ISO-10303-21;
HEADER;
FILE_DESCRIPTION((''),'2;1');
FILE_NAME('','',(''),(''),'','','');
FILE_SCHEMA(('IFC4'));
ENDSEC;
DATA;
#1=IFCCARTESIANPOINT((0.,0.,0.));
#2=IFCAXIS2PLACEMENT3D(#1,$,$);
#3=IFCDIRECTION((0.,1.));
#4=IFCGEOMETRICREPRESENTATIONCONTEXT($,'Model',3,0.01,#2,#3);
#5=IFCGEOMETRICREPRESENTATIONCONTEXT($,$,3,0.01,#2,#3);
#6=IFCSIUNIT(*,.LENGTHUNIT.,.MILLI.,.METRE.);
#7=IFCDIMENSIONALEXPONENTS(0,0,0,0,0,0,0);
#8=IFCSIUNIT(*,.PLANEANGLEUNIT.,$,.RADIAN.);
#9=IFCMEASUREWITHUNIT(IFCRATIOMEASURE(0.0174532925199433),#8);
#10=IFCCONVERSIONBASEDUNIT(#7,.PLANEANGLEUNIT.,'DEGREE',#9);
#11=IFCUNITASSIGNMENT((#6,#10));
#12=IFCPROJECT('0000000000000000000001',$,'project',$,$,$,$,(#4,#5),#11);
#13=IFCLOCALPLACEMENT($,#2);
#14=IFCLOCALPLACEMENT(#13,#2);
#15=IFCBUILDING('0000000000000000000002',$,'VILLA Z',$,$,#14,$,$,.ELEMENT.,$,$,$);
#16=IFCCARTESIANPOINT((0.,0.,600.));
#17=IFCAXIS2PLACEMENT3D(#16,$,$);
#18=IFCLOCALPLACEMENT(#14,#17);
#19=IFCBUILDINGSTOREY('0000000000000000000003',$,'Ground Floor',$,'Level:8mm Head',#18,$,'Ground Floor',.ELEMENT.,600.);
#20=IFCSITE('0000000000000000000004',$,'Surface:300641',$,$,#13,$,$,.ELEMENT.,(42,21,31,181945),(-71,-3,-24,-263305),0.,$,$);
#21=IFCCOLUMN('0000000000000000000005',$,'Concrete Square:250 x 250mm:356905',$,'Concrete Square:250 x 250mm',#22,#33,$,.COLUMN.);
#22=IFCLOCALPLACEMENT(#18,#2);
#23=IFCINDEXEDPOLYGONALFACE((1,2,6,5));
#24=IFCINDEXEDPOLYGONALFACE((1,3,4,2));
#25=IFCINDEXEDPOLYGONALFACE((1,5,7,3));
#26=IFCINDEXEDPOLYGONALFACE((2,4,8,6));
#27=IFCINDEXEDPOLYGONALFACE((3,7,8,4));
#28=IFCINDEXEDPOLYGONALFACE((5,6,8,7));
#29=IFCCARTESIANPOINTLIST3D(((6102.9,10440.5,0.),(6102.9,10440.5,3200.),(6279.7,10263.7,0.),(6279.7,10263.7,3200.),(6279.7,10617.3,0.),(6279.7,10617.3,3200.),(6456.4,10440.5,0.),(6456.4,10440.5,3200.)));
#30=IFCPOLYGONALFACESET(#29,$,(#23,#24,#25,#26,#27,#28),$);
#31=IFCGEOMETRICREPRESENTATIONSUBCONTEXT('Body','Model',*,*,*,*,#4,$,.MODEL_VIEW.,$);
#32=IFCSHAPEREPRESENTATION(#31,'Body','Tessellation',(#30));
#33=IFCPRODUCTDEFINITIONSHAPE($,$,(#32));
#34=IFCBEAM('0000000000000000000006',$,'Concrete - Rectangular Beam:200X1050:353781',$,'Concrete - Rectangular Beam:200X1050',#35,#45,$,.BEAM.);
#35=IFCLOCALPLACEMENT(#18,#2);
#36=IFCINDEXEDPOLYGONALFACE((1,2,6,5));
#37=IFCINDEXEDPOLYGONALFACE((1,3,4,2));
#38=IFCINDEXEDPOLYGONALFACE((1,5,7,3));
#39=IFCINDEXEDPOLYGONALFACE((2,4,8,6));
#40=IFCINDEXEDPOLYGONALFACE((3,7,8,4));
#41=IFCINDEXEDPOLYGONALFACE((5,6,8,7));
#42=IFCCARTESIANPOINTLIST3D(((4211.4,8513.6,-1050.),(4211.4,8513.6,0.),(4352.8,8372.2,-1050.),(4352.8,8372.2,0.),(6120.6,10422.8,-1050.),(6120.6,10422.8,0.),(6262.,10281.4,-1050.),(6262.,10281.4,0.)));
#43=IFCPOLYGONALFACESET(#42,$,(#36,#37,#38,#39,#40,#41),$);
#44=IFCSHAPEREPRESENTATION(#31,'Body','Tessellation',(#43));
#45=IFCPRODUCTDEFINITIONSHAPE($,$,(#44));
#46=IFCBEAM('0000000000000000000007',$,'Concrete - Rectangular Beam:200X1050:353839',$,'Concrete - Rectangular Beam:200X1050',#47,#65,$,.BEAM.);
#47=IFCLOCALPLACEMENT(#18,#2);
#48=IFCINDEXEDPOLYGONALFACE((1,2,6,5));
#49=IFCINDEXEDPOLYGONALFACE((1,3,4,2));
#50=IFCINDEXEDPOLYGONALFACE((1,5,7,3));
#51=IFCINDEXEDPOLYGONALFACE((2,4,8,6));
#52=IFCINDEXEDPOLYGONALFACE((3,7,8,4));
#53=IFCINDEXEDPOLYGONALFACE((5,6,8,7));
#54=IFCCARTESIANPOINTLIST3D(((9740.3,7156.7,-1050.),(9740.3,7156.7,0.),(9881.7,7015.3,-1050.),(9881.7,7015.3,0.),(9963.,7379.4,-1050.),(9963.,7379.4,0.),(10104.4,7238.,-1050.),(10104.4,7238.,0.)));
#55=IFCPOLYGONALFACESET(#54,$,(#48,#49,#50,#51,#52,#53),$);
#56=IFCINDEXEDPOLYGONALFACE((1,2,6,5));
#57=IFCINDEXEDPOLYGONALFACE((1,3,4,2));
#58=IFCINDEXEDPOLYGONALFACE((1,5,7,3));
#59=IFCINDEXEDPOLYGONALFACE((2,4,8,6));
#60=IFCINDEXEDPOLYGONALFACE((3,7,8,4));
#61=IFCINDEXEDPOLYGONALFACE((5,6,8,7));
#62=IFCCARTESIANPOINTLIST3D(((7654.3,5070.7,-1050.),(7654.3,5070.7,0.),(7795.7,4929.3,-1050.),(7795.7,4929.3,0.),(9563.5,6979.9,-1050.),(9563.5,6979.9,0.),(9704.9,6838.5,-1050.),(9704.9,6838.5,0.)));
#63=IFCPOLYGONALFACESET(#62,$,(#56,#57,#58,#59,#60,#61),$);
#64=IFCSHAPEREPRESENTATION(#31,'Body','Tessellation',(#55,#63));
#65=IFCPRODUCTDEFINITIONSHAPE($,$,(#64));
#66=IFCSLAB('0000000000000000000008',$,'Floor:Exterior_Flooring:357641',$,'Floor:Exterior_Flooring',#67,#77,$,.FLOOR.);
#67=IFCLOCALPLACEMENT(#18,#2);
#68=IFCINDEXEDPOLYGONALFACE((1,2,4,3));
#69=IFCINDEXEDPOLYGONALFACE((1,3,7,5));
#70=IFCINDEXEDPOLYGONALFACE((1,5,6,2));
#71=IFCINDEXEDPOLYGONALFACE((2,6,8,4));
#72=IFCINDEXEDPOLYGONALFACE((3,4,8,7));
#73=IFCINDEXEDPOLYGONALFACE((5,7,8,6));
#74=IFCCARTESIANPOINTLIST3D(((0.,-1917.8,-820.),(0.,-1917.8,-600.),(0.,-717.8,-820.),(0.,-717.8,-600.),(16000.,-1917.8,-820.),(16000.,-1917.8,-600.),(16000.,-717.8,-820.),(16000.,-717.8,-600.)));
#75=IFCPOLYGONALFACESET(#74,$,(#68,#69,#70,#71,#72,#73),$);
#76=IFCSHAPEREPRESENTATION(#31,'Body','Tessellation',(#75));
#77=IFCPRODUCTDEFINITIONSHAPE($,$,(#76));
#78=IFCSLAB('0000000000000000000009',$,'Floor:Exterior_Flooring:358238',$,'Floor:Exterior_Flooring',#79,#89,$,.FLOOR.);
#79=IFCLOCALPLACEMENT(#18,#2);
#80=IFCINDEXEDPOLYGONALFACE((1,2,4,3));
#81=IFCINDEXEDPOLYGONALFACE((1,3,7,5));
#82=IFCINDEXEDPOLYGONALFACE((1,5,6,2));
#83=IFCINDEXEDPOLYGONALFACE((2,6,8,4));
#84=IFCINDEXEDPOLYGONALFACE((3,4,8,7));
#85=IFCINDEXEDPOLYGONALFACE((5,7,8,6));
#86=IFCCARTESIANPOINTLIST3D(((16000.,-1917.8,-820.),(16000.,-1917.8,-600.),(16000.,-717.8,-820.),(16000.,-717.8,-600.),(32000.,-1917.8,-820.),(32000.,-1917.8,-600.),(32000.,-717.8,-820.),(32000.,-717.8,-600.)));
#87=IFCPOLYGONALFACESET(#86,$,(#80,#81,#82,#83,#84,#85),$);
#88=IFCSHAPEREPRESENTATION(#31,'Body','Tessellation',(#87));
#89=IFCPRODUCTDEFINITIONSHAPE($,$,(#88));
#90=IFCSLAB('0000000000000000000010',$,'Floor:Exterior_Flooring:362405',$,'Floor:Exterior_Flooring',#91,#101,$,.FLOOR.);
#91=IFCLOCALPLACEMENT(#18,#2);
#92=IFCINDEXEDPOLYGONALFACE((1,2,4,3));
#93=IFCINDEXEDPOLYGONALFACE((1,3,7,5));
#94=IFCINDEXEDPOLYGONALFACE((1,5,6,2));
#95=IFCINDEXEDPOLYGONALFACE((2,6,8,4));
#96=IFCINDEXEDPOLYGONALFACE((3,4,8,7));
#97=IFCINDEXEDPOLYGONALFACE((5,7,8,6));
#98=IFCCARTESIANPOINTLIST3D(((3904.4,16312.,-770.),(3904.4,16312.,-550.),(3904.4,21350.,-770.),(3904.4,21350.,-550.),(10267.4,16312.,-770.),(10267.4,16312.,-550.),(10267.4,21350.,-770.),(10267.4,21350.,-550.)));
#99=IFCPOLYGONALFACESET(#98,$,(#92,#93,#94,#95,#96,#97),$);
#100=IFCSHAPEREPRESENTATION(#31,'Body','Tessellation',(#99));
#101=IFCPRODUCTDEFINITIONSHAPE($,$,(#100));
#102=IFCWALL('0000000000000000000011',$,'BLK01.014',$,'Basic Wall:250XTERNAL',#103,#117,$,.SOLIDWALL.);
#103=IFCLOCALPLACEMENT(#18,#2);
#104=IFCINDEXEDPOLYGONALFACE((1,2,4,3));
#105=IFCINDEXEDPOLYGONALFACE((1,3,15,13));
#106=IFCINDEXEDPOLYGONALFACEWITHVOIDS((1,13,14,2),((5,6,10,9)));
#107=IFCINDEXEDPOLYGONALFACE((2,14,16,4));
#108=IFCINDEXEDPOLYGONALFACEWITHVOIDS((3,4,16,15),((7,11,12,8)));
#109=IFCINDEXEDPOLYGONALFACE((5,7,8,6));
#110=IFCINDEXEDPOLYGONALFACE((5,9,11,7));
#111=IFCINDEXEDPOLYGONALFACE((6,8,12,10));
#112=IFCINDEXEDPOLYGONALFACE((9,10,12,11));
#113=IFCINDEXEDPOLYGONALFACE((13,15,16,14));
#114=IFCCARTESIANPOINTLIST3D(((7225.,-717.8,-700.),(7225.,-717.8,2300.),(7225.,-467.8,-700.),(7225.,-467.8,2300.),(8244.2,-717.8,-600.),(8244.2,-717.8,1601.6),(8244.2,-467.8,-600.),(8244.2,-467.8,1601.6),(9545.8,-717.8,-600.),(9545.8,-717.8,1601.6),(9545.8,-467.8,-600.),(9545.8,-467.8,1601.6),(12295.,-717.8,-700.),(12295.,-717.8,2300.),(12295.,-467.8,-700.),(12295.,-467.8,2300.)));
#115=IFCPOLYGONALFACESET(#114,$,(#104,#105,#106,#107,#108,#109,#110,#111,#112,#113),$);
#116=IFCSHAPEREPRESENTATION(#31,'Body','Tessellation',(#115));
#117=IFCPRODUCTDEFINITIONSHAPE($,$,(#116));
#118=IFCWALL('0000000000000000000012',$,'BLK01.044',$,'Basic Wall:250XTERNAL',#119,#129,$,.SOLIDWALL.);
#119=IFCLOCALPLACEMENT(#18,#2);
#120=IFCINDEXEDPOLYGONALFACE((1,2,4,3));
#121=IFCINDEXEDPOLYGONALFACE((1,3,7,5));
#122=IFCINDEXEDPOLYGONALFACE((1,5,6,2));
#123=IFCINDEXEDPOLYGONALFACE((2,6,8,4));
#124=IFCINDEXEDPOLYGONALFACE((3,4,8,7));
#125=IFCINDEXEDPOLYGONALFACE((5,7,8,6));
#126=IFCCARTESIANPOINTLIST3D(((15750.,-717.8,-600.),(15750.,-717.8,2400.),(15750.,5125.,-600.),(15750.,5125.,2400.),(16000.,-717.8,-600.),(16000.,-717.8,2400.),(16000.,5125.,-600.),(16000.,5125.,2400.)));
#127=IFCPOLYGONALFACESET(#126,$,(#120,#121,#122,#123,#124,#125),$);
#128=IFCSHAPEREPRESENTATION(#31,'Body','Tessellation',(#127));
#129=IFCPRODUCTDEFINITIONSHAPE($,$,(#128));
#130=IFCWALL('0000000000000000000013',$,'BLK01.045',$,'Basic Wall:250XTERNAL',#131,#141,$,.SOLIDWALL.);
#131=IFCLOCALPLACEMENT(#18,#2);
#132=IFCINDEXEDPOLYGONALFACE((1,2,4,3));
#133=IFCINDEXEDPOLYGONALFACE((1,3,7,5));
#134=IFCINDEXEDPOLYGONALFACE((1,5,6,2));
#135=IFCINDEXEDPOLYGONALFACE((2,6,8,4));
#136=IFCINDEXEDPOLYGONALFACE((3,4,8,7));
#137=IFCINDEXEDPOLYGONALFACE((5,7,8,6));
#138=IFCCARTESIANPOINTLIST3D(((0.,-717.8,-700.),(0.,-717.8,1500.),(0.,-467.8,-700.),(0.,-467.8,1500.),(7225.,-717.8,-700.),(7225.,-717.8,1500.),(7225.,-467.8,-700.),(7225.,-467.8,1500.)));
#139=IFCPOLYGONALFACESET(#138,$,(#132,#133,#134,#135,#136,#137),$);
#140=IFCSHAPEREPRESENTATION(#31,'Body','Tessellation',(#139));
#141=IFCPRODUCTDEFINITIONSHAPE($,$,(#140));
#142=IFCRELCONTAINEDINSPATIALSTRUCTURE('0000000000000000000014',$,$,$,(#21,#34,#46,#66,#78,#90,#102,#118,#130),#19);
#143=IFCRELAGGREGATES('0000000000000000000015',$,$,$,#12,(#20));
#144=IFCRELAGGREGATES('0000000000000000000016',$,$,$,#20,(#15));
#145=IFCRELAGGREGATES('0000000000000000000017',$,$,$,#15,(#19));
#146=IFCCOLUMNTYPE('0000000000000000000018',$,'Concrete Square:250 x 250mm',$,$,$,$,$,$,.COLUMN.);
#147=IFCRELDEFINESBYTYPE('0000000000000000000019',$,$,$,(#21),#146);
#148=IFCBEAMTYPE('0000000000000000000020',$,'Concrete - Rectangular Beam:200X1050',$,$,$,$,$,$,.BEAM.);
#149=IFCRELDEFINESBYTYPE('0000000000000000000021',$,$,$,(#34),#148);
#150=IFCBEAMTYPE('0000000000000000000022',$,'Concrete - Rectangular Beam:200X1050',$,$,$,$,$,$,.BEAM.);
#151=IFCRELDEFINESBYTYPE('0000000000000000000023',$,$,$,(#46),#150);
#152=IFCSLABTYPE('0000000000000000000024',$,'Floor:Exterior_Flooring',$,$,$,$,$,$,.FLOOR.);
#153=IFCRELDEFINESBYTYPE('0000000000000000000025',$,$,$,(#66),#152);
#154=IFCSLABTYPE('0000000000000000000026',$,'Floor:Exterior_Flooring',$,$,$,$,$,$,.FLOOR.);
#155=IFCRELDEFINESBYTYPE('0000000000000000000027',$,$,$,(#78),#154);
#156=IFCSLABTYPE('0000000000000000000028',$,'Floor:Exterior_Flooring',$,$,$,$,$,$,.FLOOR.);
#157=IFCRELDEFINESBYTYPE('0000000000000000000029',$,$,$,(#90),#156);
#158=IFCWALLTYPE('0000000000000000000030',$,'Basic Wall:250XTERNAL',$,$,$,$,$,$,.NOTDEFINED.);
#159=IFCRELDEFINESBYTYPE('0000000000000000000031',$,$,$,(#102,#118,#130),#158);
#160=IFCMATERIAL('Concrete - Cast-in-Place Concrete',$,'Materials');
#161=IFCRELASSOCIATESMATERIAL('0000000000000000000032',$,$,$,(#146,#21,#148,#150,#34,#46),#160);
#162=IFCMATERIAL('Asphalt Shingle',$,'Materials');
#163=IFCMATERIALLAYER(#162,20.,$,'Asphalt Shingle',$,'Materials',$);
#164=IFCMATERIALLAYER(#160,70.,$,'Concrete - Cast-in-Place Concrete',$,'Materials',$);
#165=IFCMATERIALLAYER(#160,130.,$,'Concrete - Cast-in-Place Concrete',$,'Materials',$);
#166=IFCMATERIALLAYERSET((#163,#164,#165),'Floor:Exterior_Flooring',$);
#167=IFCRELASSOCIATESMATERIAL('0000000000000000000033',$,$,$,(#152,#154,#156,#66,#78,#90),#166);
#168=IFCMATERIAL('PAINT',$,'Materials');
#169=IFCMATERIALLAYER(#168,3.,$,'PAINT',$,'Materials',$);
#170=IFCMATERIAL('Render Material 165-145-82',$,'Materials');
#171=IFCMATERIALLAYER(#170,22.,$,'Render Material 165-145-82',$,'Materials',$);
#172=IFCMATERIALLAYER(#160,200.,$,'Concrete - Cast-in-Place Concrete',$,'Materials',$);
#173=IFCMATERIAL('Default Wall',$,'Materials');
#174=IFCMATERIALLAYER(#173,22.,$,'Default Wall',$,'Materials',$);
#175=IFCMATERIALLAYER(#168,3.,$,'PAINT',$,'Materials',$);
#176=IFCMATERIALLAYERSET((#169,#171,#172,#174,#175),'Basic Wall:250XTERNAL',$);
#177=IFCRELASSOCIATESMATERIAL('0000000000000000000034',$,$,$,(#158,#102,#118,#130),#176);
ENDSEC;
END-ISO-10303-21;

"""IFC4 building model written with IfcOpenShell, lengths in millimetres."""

from ifc_helpers import new_model, entity, si_unit, converted_unit, direction, frame, frame_2d, origin, origin_2d_with_axis, place, context, subcontext, project, spatial, rectangle, extrude, source, transform, mapped, material, layer, layer_set, layer_usage, material_profile, profile_set, profile_usage, type_object, type_shapes, element, save


model = new_model("IFC4")

# Units and contexts
model_context = context("Model", 3, precision=0.01, world=origin(), true_north=direction((0.0, 1.0)))
context_of_model = context(None, 3, precision=0.01, world=origin(), true_north=direction((0.0, 1.0)))
body_context = subcontext(model_context, "Body", "Model", "MODEL_VIEW")
ifc_project = project(units=[si_unit("LENGTHUNIT", "METRE", prefix="MILLI"), converted_unit("PLANEANGLEUNIT", "DEGREE", entity("IfcRatioMeasure", 0.0174532925199433), si_unit("PLANEANGLEUNIT", "RADIAN"), dimensions=[0, 0, 0, 0, 0, 0, 0])], contexts=[model_context, context_of_model])

# Site, building, storey
site_placement = place(None, origin())
site = spatial("IfcSite", under=ifc_project, at=site_placement, Name="Surface:300641", CompositionType="ELEMENT", RefLatitude=(42, 21, 31, 181945), RefLongitude=(-71, -3, -24, -263305), RefElevation=0.0)
building_placement = place(site_placement, origin())
building = spatial("IfcBuilding", under=site, at=building_placement, Name="VILLA Z", CompositionType="ELEMENT")
storey_placement = place(building_placement, frame((0.0, 0.0, 600.0)))
storey = spatial("IfcBuildingStorey", under=building, at=storey_placement, Name="Ground Floor", ObjectType="Level:8mm Head", LongName="Ground Floor", CompositionType="ELEMENT", Elevation=600.0)

# Column
ifc_material_1 = material(Name="Concrete - Cast-in-Place Concrete", Category="Materials")
ifc_material_profile_1 = material_profile(ifc_material_1, rectangle(XDim=250.0, YDim=250.0, at=frame_2d((0.0, 0.0), x_axis=(1.0, 0.0))), Name="250 x 250mm")
ifc_profile_set_1 = profile_set([ifc_material_profile_1], Name="250 x 250mm")
ifc_profile_usage_1 = profile_usage(ifc_profile_set_1)
column_type = type_object("IfcColumnType", Name="Concrete Square:250 x 250mm", PredefinedType="COLUMN", material=ifc_profile_set_1)
shared_shape_1 = source(origin(), body_context, "Body", "SweptSolid", [
    extrude(rectangle(XDim=250.0, YDim=250.0, at=origin_2d_with_axis()), frame((6279.7, 10440.5, 600.0), z_axis=(0.0, 0.0, 1.0), x_axis=(-0.707107, 0.707107, 0.0)), (0.0, 0.0, 1.0), 3200.0),
])
type_shapes(column_type, [shared_shape_1])
column_placement = place(storey_placement, frame((0.0, 0.0, -600.0)))
element("IfcColumn", 1, at=column_placement, inside=storey, type_object=column_type, material=ifc_profile_usage_1, Name="Concrete Square:250 x 250mm:356905", ObjectType="Concrete Square:250 x 250mm", PredefinedType="COLUMN", context=body_context, shape_type="MappedRepresentation", body=[
    mapped(shared_shape_1, transform((0.0, 0.0, 0.0), scale=1.0)),
])

# Beams
ifc_material_profile_2 = material_profile(ifc_material_1, rectangle(XDim=1050.0, YDim=200.0, at=frame_2d((0.0, 0.0), x_axis=(1.0, 0.0))), Name="200X1050")
ifc_profile_set_2 = profile_set([ifc_material_profile_2], Name="200X1050")
ifc_profile_usage_2 = profile_usage(ifc_profile_set_2, cardinal=8)
beam_type_1 = type_object("IfcBeamType", Name="Concrete - Rectangular Beam:200X1050", PredefinedType="BEAM", material=ifc_profile_set_2)
shared_shape_2 = source(origin(), body_context, "Body", "SweptSolid", [
    extrude(rectangle(XDim=1050.0, YDim=200.0, at=frame_2d((0.0, 0.0), x_axis=(1.0, 0.0))), frame((6191.3, 10352.1, 75.0), z_axis=(-0.707107, -0.707107, 0.0), x_axis=(0.0, 0.0, -1.0)), (0.0, 0.0, 1.0), 2700.0),
])
type_shapes(beam_type_1, [shared_shape_2])
beam_1_placement = place(storey_placement, frame((0.0, 0.0, -600.0)))
element("IfcBeam", 2, at=beam_1_placement, inside=storey, type_object=beam_type_1, material=ifc_profile_usage_2, Name="Concrete - Rectangular Beam:200X1050:353781", ObjectType="Concrete - Rectangular Beam:200X1050", PredefinedType="BEAM", context=body_context, shape_type="MappedRepresentation", body=[
    mapped(shared_shape_2, transform((0.0, 0.0, 0.0), scale=1.0)),
])
ifc_profile_usage_3 = profile_usage(ifc_profile_set_2, cardinal=8)
beam_type_2 = type_object("IfcBeamType", Name="Concrete - Rectangular Beam:200X1050", PredefinedType="BEAM", material=ifc_profile_set_2)
shared_shape_3 = source(origin(), body_context, "Body", "SweptSolid", [
    extrude(rectangle(XDim=1050.0, YDim=200.0, at=frame_2d((0.0, 0.0), x_axis=(1.0, 0.0))), frame((9811.0, 7086.0, 75.0), z_axis=(0.707107, 0.707107, 0.0), x_axis=(0.0, 0.0, 1.0)), (0.0, 0.0, 1.0), 315.0),
    extrude(rectangle(XDim=1050.0, YDim=200.0, at=frame_2d((0.0, 0.0), x_axis=(1.0, 0.0))), frame((7725.0, 5000.0, 75.0), z_axis=(0.707107, 0.707107, 0.0), x_axis=(0.0, 0.0, 1.0)), (0.0, 0.0, 1.0), 2700.0),
])
type_shapes(beam_type_2, [shared_shape_3])
beam_2_placement = place(storey_placement, frame((0.0, 0.0, -600.0)))
element("IfcBeam", 3, at=beam_2_placement, inside=storey, type_object=beam_type_2, material=ifc_profile_usage_3, Name="Concrete - Rectangular Beam:200X1050:353839", ObjectType="Concrete - Rectangular Beam:200X1050", PredefinedType="BEAM", context=body_context, shape_type="MappedRepresentation", body=[
    mapped(shared_shape_3, transform((0.0, 0.0, 0.0), scale=1.0)),
])

# Slabs
ifc_material_2 = material(Name="Asphalt Shingle", Category="Materials")
ifc_layer_1 = layer(ifc_material_2, 20.0, Name="Asphalt Shingle", Category="Materials")
ifc_layer_2 = layer(ifc_material_1, 70.0, Name="Concrete - Cast-in-Place Concrete", Category="Materials")
ifc_layer_3 = layer(ifc_material_1, 130.0, Name="Concrete - Cast-in-Place Concrete", Category="Materials")
ifc_layer_set_1 = layer_set([ifc_layer_1, ifc_layer_2, ifc_layer_3], Name="Floor:Exterior_Flooring")
ifc_layer_usage_1 = layer_usage(ifc_layer_set_1, "AXIS3", "POSITIVE", 0.0)
slab_type_1 = type_object("IfcSlabType", Name="Floor:Exterior_Flooring", PredefinedType="FLOOR", material=ifc_layer_set_1)
slab_1_placement = place(storey_placement, origin())
element("IfcSlab", 4, at=slab_1_placement, inside=storey, type_object=slab_type_1, material=ifc_layer_usage_1, Name="Floor:Exterior_Flooring:357641", ObjectType="Floor:Exterior_Flooring", PredefinedType="FLOOR", context=body_context, shape_type="SweptSolid", body=[
    extrude(rectangle(XDim=1200.0, YDim=16000.0, at=origin_2d_with_axis()), frame((8000.0, -1317.8, -600.0), z_axis=(0.0, 0.0, -1.0), x_axis=(0.0, 1.0, 0.0)), (0.0, 0.0, 1.0), 220.0),
])
ifc_layer_usage_2 = layer_usage(ifc_layer_set_1, "AXIS3", "POSITIVE", 0.0)
slab_type_2 = type_object("IfcSlabType", Name="Floor:Exterior_Flooring", PredefinedType="FLOOR", material=ifc_layer_set_1)
slab_2_placement = place(storey_placement, origin())
element("IfcSlab", 5, at=slab_2_placement, inside=storey, type_object=slab_type_2, material=ifc_layer_usage_2, Name="Floor:Exterior_Flooring:358238", ObjectType="Floor:Exterior_Flooring", PredefinedType="FLOOR", context=body_context, shape_type="SweptSolid", body=[
    extrude(rectangle(XDim=1200.0, YDim=16000.0, at=origin_2d_with_axis()), frame((24000.0, -1317.8, -600.0), z_axis=(0.0, 0.0, -1.0), x_axis=(0.0, 1.0, 0.0)), (0.0, 0.0, 1.0), 220.0),
])
ifc_layer_usage_3 = layer_usage(ifc_layer_set_1, "AXIS3", "POSITIVE", 0.0)
slab_type_3 = type_object("IfcSlabType", Name="Floor:Exterior_Flooring", PredefinedType="FLOOR", material=ifc_layer_set_1)
slab_3_placement = place(storey_placement, origin())
element("IfcSlab", 6, at=slab_3_placement, inside=storey, type_object=slab_type_3, material=ifc_layer_usage_3, Name="Floor:Exterior_Flooring:362405", ObjectType="Floor:Exterior_Flooring", PredefinedType="FLOOR", context=body_context, shape_type="SweptSolid", body=[
    extrude(rectangle(XDim=5038.0, YDim=6362.9, at=origin_2d_with_axis()), frame((7085.9, 18831.0, -550.0), z_axis=(0.0, 0.0, -1.0), x_axis=(0.0, 1.0, 0.0)), (0.0, 0.0, 1.0), 220.0),
])

# Wall, opening
ifc_material_3 = material(Name="PAINT", Category="Materials")
ifc_layer_4 = layer(ifc_material_3, 3.0, Name="PAINT", Category="Materials")
ifc_material_4 = material(Name="Render Material 165-145-82", Category="Materials")
ifc_layer_5 = layer(ifc_material_4, 22.0, Name="Render Material 165-145-82", Category="Materials")
ifc_layer_6 = layer(ifc_material_1, 200.0, Name="Concrete - Cast-in-Place Concrete", Category="Materials")
ifc_material_5 = material(Name="Default Wall", Category="Materials")
ifc_layer_7 = layer(ifc_material_5, 22.0, Name="Default Wall", Category="Materials")
ifc_layer_8 = layer(ifc_material_3, 3.0, Name="PAINT", Category="Materials")
ifc_layer_set_2 = layer_set([ifc_layer_4, ifc_layer_5, ifc_layer_6, ifc_layer_7, ifc_layer_8], Name="Basic Wall:250XTERNAL")
ifc_layer_usage_4 = layer_usage(ifc_layer_set_2, "AXIS2", "NEGATIVE", 125.0)
wall_type_1 = type_object("IfcWallType", Name="Basic Wall:250XTERNAL", PredefinedType="NOTDEFINED", material=ifc_layer_set_2)
wall_1_placement = place(storey_placement, frame((12295.0, -592.8, -700.0), z_axis=(0.0, 0.0, 1.0), x_axis=(-1.0, 0.0, 0.0)))
wall_1 = element("IfcWall", 7, at=wall_1_placement, inside=storey, type_object=wall_type_1, material=ifc_layer_usage_4, Name="BLK01.014", ObjectType="Basic Wall:250XTERNAL", PredefinedType="SOLIDWALL", context=body_context, shape_type="SweptSolid", body=[
    extrude(rectangle(XDim=5070.0, YDim=250.0, at=frame_2d((2535.0, 0.0), x_axis=(-1.0, 0.0))), origin(), (0.0, 0.0, 1.0), 3000.0),
])
opening_1_placement = place(wall_1_placement, frame((4050.8, 125.0, 100.0)))
element("IfcOpeningElement", 8, at=opening_1_placement, cuts=wall_1, ObjectType="Opening", PredefinedType="OPENING", context=body_context, shape_type="SweptSolid", body=[
    extrude(rectangle(XDim=2201.6, YDim=1301.6, at=frame_2d((1100.8, 650.8), x_axis=(1.0, 0.0))), frame((0.0, 0.0, 0.0), z_axis=(0.0, -1.0, 0.0), x_axis=(0.0, 0.0, 1.0)), (0.0, 0.0, 1.0), 250.0),
])

# Walls
ifc_layer_usage_5 = layer_usage(ifc_layer_set_2, "AXIS2", "NEGATIVE", 125.0)
wall_2_placement = place(storey_placement, frame((15875.0, -717.8, -600.0), z_axis=(0.0, 0.0, 1.0), x_axis=(0.0, 1.0, 0.0)))
element("IfcWall", 9, at=wall_2_placement, inside=storey, type_object=wall_type_1, material=ifc_layer_usage_5, Name="BLK01.044", ObjectType="Basic Wall:250XTERNAL", PredefinedType="SOLIDWALL", context=body_context, shape_type="SweptSolid", body=[
    extrude(rectangle(XDim=5842.8, YDim=250.0, at=frame_2d((2921.4, 0.0), x_axis=(-1.0, 0.0))), origin(), (0.0, 0.0, 1.0), 3000.0),
])
ifc_layer_usage_6 = layer_usage(ifc_layer_set_2, "AXIS2", "NEGATIVE", 125.0)
wall_3_placement = place(storey_placement, frame((7225.0, -592.8, -700.0), z_axis=(0.0, 0.0, 1.0), x_axis=(-1.0, 0.0, 0.0)))
element("IfcWall", 10, at=wall_3_placement, inside=storey, type_object=wall_type_1, material=ifc_layer_usage_6, Name="BLK01.045", ObjectType="Basic Wall:250XTERNAL", PredefinedType="SOLIDWALL", context=body_context, shape_type="SweptSolid", body=[
    extrude(rectangle(XDim=7225.0, YDim=250.0, at=frame_2d((3612.5, 0.0), x_axis=(-1.0, 0.0))), origin(), (0.0, 0.0, 1.0), 2200.0),
])

save(model, "model.ifc")
